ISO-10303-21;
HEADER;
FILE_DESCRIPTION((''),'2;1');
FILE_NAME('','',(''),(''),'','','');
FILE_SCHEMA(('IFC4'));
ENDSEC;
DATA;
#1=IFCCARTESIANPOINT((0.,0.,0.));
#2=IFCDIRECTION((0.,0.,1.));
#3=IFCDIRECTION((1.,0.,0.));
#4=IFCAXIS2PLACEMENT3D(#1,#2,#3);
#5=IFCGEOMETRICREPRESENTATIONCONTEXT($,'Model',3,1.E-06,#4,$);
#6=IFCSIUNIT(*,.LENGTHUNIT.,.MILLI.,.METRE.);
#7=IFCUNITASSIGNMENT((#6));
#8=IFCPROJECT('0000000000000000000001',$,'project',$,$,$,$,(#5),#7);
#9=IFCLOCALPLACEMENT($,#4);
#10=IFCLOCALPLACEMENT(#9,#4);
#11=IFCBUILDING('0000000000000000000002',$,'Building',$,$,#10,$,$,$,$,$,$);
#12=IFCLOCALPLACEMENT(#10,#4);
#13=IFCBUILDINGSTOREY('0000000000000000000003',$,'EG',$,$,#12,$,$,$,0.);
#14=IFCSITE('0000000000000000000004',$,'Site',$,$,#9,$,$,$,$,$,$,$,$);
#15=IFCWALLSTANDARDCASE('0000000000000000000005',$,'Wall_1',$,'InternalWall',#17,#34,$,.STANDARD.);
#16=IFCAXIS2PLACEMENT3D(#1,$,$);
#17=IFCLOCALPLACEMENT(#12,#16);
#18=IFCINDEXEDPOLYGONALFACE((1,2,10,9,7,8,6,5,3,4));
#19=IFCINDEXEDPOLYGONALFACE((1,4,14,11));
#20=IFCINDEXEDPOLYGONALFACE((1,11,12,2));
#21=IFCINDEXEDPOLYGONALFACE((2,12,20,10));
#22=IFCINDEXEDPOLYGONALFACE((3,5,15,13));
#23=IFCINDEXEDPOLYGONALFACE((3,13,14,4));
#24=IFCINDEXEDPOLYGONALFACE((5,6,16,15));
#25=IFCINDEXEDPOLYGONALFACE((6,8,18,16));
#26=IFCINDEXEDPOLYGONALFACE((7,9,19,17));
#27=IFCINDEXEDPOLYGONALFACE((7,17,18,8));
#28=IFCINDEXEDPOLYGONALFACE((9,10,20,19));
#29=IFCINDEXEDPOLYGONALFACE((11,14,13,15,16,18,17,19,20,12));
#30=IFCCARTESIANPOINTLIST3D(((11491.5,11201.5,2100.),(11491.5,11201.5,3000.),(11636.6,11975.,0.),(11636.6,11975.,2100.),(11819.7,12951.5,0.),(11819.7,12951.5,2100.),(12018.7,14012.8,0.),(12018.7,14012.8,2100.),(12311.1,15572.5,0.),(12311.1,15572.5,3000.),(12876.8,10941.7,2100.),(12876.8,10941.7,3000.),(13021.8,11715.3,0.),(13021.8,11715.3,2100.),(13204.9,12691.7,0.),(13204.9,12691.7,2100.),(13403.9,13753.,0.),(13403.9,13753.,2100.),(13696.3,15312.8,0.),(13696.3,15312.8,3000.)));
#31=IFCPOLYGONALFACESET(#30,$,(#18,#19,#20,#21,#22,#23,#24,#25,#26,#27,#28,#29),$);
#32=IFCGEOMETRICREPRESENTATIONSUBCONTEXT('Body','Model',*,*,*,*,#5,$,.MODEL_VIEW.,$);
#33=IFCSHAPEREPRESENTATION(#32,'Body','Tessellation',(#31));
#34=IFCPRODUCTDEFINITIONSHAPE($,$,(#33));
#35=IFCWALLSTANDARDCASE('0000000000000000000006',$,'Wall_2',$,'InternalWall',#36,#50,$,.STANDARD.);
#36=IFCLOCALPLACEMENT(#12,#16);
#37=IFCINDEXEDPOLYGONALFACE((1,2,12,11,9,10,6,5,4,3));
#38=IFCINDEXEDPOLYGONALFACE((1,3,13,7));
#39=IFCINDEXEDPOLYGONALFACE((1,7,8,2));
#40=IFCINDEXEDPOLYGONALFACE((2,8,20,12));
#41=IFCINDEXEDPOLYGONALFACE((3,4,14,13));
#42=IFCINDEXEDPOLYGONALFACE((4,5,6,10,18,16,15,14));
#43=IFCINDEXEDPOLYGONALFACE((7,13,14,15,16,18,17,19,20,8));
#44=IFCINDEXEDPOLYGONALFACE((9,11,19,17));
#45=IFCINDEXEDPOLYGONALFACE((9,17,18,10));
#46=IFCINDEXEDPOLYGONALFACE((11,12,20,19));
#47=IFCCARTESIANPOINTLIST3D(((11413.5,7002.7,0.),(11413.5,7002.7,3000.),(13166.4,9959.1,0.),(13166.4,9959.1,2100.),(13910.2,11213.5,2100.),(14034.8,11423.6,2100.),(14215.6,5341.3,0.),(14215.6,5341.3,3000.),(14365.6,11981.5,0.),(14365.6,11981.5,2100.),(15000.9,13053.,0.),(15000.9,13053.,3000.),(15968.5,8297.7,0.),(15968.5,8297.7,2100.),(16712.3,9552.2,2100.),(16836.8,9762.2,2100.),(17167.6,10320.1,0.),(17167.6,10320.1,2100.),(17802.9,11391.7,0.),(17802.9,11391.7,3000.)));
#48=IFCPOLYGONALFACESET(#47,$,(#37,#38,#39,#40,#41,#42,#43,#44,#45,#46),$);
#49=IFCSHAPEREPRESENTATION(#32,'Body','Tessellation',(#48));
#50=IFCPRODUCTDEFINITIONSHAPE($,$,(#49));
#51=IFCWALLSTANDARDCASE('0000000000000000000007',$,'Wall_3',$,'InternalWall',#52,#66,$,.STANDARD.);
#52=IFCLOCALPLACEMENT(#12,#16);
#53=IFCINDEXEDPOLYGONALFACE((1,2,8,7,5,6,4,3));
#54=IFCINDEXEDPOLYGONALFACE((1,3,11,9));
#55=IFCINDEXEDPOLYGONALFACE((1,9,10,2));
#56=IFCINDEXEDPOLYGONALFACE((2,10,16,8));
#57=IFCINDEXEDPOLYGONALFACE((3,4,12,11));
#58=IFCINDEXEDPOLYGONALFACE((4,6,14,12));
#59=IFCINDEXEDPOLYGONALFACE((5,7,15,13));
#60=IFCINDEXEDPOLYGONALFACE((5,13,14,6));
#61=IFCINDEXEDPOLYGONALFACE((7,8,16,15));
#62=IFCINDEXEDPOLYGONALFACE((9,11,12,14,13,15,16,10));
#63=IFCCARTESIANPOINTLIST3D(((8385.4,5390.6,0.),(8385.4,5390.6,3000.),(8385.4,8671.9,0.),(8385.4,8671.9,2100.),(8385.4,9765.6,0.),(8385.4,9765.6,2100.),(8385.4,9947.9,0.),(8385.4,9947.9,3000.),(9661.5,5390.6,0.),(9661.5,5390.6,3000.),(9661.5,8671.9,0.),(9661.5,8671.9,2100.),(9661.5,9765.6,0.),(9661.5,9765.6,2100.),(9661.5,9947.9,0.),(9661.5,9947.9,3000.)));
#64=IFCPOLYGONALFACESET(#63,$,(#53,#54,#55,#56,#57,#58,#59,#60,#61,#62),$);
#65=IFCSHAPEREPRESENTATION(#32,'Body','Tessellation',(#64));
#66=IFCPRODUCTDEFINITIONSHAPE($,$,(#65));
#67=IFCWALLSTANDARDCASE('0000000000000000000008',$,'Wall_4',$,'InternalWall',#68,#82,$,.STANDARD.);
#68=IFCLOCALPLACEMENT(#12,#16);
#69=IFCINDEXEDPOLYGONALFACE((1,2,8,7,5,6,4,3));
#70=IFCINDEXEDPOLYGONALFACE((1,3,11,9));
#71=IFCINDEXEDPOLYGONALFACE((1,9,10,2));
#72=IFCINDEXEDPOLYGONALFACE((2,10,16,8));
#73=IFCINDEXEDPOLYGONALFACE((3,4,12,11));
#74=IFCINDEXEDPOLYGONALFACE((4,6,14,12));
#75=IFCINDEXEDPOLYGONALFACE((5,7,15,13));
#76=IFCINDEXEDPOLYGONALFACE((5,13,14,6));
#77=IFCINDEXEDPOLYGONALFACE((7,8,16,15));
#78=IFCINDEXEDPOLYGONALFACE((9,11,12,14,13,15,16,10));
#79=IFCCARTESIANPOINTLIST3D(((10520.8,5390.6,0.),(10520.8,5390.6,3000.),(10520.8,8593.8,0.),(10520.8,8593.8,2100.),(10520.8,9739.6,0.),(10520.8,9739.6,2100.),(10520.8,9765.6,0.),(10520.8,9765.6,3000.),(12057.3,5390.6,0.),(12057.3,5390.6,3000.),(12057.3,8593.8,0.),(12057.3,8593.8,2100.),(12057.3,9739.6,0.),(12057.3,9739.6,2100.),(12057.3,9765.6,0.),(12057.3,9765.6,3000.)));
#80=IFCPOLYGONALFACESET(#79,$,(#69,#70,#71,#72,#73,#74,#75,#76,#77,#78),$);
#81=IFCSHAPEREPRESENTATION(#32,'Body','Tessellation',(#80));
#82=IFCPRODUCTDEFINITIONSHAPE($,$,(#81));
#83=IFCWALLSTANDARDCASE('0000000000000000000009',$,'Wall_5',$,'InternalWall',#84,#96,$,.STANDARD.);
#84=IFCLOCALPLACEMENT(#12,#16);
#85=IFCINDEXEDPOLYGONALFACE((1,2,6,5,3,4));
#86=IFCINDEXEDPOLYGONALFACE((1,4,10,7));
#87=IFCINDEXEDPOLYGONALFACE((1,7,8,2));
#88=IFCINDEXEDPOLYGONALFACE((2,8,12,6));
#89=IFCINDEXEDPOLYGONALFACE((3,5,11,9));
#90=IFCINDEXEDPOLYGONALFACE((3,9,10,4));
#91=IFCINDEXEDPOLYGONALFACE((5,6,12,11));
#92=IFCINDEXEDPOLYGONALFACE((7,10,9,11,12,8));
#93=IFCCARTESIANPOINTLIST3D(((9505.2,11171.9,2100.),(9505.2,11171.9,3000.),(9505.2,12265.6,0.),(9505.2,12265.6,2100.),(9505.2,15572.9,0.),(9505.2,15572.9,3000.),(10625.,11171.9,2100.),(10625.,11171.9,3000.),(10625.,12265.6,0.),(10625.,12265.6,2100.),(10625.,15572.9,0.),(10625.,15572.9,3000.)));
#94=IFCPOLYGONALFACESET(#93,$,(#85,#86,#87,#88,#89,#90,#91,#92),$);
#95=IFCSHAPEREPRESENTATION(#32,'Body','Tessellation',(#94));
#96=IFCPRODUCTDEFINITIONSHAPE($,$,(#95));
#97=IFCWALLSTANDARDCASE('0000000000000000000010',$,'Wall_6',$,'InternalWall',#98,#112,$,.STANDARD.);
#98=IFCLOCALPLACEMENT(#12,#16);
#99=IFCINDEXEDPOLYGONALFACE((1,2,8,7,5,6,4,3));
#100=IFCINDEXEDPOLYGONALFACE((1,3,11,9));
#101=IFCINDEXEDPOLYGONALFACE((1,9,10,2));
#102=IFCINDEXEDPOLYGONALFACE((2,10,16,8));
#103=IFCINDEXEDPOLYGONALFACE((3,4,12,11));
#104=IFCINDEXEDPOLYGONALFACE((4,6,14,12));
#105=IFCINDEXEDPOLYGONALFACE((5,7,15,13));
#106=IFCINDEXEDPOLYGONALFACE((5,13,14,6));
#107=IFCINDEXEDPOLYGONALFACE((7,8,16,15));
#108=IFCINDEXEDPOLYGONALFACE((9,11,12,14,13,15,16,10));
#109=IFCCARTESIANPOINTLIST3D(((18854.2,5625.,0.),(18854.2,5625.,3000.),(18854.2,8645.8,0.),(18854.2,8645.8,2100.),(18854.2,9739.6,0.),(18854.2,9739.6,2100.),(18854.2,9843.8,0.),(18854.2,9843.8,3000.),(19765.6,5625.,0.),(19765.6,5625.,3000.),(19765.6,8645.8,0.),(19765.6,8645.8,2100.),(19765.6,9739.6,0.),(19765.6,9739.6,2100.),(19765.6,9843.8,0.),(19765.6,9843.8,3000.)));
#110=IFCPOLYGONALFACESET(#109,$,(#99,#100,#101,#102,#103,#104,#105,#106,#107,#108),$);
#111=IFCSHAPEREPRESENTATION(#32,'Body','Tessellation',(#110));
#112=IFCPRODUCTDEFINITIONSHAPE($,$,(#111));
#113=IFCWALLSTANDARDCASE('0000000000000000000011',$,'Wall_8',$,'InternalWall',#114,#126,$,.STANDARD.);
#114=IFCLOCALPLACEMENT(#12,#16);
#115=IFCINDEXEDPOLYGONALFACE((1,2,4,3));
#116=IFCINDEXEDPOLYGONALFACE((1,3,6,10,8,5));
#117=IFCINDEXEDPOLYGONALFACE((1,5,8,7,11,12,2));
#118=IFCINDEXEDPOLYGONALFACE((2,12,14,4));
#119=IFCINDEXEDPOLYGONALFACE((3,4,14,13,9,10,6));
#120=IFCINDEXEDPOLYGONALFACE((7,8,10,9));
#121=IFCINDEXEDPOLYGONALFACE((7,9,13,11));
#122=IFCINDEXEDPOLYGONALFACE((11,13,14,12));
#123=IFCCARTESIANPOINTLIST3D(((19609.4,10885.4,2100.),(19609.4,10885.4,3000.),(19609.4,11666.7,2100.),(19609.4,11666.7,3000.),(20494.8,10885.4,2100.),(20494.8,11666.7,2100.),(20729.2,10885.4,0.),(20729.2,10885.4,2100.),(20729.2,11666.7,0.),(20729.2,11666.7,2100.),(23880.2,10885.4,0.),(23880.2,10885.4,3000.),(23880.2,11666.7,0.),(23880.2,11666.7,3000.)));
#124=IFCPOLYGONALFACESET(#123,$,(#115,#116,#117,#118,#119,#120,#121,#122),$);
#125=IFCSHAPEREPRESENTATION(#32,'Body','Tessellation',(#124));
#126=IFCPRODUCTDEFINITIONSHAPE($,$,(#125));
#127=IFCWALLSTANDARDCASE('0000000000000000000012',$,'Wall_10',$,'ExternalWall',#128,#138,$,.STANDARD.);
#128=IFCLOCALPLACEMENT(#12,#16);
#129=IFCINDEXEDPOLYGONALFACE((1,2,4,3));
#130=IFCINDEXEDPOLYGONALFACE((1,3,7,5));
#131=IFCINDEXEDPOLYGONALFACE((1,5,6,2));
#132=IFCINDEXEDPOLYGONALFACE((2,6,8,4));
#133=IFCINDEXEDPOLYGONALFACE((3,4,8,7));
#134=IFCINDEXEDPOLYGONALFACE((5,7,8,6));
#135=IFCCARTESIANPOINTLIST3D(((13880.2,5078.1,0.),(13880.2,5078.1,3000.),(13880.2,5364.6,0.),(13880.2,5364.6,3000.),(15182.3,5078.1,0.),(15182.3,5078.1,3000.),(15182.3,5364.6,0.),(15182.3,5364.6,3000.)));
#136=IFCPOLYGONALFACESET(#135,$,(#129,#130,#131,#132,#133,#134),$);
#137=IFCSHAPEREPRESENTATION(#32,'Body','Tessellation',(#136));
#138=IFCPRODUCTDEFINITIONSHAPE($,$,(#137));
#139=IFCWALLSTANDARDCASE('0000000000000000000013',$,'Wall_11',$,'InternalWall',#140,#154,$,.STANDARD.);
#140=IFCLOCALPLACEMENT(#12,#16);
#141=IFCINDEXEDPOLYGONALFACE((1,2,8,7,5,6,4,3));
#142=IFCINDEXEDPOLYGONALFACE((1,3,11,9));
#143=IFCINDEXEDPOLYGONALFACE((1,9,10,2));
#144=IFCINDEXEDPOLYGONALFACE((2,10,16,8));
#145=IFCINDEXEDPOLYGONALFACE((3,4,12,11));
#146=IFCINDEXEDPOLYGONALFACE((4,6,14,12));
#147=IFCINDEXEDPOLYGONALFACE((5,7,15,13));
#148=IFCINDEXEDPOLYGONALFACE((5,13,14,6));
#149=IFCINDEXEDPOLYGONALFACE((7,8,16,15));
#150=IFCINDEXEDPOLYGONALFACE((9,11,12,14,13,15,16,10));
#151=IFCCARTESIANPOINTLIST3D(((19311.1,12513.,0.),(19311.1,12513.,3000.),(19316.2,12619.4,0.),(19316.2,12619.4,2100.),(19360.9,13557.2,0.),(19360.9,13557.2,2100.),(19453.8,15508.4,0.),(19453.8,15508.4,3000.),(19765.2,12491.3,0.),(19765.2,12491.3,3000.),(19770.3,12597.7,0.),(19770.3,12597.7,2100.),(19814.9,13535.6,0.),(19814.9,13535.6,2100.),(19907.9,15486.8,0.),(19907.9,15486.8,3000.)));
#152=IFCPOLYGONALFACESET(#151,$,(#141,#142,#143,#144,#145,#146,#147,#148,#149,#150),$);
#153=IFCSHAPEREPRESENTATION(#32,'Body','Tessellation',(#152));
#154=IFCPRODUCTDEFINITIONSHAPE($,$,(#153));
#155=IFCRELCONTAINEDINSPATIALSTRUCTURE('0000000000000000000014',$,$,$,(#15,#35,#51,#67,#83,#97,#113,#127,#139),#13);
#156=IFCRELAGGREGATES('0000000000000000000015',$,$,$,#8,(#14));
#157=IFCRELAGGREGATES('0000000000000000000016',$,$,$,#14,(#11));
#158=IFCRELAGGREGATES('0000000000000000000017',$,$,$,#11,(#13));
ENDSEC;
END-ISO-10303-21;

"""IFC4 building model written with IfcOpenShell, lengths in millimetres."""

from ifc_helpers import new_model, si_unit, frame, origin_with_axes, place, context, subcontext, project, spatial, rectangle, extrude, element, save


model = new_model("IFC4")

# Units and contexts
model_context = context("Model", 3, precision=1e-06, world=origin_with_axes())
body_context = subcontext(model_context, "Body", "Model", "MODEL_VIEW")
ifc_project = project(units=[si_unit("LENGTHUNIT", "METRE", prefix="MILLI")], contexts=[model_context])

# Site, building, storey
site_placement = place(None, origin_with_axes())
site = spatial("IfcSite", under=ifc_project, at=site_placement, Name="Site")
building_placement = place(site_placement, origin_with_axes())
building = spatial("IfcBuilding", under=site, at=building_placement, Name="Building")
storey_placement = place(building_placement, origin_with_axes())
storey = spatial("IfcBuildingStorey", under=building, at=storey_placement, Name="EG", Elevation=0.0)

# Walls, openings
wall_1_placement = place(storey_placement, origin_with_axes())
wall_1 = element("IfcWallStandardCase", 1, at=wall_1_placement, inside=storey, Name="Wall_1", ObjectType="InternalWall", PredefinedType="STANDARD", context=body_context, shape_type="SweptSolid", body=[
    extrude(rectangle(XDim=4447.2, YDim=1409.4), frame((12593.9, 13257.1, 0.0), z_axis=(0.0, 0.0, 1.0), x_axis=(0.184288, 0.982872, 0.0)), (0.0, 0.0, 1.0), 3000.0),
])
opening_1_placement = place(wall_1_placement, origin_with_axes())
element("IfcOpeningElement", 2, at=opening_1_placement, inside=storey, cuts=wall_1, context=body_context, shape_type="SweptSolid", body=[
    extrude(rectangle(XDim=1079.8, YDim=1409.4), frame((12611.8, 13352.3, 0.0), z_axis=(0.0, 0.0, 1.0), x_axis=(0.184288, 0.982872, 0.0)), (0.0, 0.0, 1.0), 2100.0),
])
opening_2_placement = place(wall_1_placement, origin_with_axes())
element("IfcOpeningElement", 3, at=opening_2_placement, inside=storey, cuts=wall_1, context=body_context, shape_type="SweptSolid", body=[
    extrude(rectangle(XDim=787.1, YDim=1409.4), frame((12256.7, 11458.4, 0.0), z_axis=(0.0, 0.0, 1.0), x_axis=(0.184288, 0.982872, 0.0)), (0.0, 0.0, 1.0), 2100.0),
])
wall_2_placement = place(storey_placement, origin_with_axes())
wall_2 = element("IfcWallStandardCase", 4, at=wall_2_placement, inside=storey, Name="Wall_2", ObjectType="InternalWall", PredefinedType="STANDARD", context=body_context, shape_type="SweptSolid", body=[
    extrude(rectangle(XDim=7033.9, YDim=3257.5), frame((14608.2, 9197.2, 0.0), z_axis=(0.0, 0.0, 1.0), x_axis=(-0.510011, -0.860168, 0.0)), (0.0, 0.0, 1.0), 3000.0),
])
opening_3_placement = place(wall_2_placement, origin_with_axes())
element("IfcOpeningElement", 5, at=opening_3_placement, inside=storey, cuts=wall_2, context=body_context, shape_type="SweptSolid", body=[
    extrude(rectangle(XDim=1702.6, YDim=3257.5), frame((15001.6, 9860.7, 0.0), z_axis=(0.0, 0.0, 1.0), x_axis=(-0.510011, -0.860168, 0.0)), (0.0, 0.0, 1.0), 2100.0),
])
opening_4_placement = place(wall_2_placement, origin_with_axes())
element("IfcOpeningElement", 6, at=opening_4_placement, inside=storey, cuts=wall_2, context=body_context, shape_type="SweptSolid", body=[
    extrude(rectangle(XDim=892.8, YDim=3257.5), frame((15538.9, 10766.8, 0.0), z_axis=(0.0, 0.0, 1.0), x_axis=(-0.510011, -0.860168, 0.0)), (0.0, 0.0, 1.0), 2100.0),
])
wall_3_placement = place(storey_placement, origin_with_axes())
wall_3 = element("IfcWallStandardCase", 7, at=wall_3_placement, inside=storey, Name="Wall_3", ObjectType="InternalWall", PredefinedType="STANDARD", context=body_context, shape_type="SweptSolid", body=[
    extrude(rectangle(XDim=4557.3, YDim=1276.0), frame((9023.4, 7669.3, 0.0), z_axis=(0.0, 0.0, 1.0), x_axis=(0.0, 1.0, 0.0)), (0.0, 0.0, 1.0), 3000.0),
])
opening_5_placement = place(wall_3_placement, origin_with_axes())
element("IfcOpeningElement", 8, at=opening_5_placement, inside=storey, cuts=wall_3, context=body_context, shape_type="SweptSolid", body=[
    extrude(rectangle(XDim=1093.8, YDim=1276.0), frame((9023.4, 9218.8, 0.0), z_axis=(0.0, 0.0, 1.0), x_axis=(0.0, 1.0, 0.0)), (0.0, 0.0, 1.0), 2100.0),
])
opening_6_placement = place(wall_3_placement, origin_with_axes())
element("IfcOpeningElement", 9, at=opening_6_placement, inside=storey, cuts=wall_3, context=body_context, shape_type="SweptSolid", body=[
    extrude(rectangle(XDim=900.0, YDim=1276.0), frame((8050.2, 10554.7, 0.0), z_axis=(0.0, 0.0, 1.0), x_axis=(0.0, 1.0, 0.0)), (0.0, 0.0, 1.0), 2100.0),
])

# Walls, openings
wall_4_placement = place(storey_placement, origin_with_axes())
wall_4 = element("IfcWallStandardCase", 10, at=wall_4_placement, inside=storey, Name="Wall_4", ObjectType="InternalWall", PredefinedType="STANDARD", context=body_context, shape_type="SweptSolid", body=[
    extrude(rectangle(XDim=4375.0, YDim=1536.5), frame((11289.1, 7578.1, 0.0), z_axis=(0.0, 0.0, 1.0), x_axis=(0.0, 1.0, 0.0)), (0.0, 0.0, 1.0), 3000.0),
])
opening_7_placement = place(wall_4_placement, origin_with_axes())
element("IfcOpeningElement", 11, at=opening_7_placement, inside=storey, cuts=wall_4, context=body_context, shape_type="SweptSolid", body=[
    extrude(rectangle(XDim=1145.8, YDim=1536.5), frame((11289.1, 9166.7, 0.0), z_axis=(0.0, 0.0, 1.0), x_axis=(0.0, 1.0, 0.0)), (0.0, 0.0, 1.0), 2100.0),
])
wall_5_placement = place(storey_placement, origin_with_axes())
wall_5 = element("IfcWallStandardCase", 12, at=wall_5_placement, inside=storey, Name="Wall_5", ObjectType="InternalWall", PredefinedType="STANDARD", context=body_context, shape_type="SweptSolid", body=[
    extrude(rectangle(XDim=4401.0, YDim=1119.8), frame((10065.1, 13372.4, 0.0), z_axis=(0.0, 0.0, 1.0), x_axis=(0.0, -1.0, 0.0)), (0.0, 0.0, 1.0), 3000.0),
])
opening_8_placement = place(wall_5_placement, origin_with_axes())
element("IfcOpeningElement", 13, at=opening_8_placement, inside=storey, cuts=wall_5, context=body_context, shape_type="SweptSolid", body=[
    extrude(rectangle(XDim=1093.8, YDim=1119.8), frame((10065.1, 11718.8, 0.0), z_axis=(0.0, 0.0, 1.0), x_axis=(0.0, -1.0, 0.0)), (0.0, 0.0, 1.0), 2100.0),
])
wall_6_placement = place(storey_placement, origin_with_axes())
wall_6 = element("IfcWallStandardCase", 14, at=wall_6_placement, inside=storey, Name="Wall_6", ObjectType="InternalWall", PredefinedType="STANDARD", context=body_context, shape_type="SweptSolid", body=[
    extrude(rectangle(XDim=4218.8, YDim=911.5), frame((19309.9, 7734.4, 0.0), z_axis=(0.0, 0.0, 1.0), x_axis=(0.0, 1.0, 0.0)), (0.0, 0.0, 1.0), 3000.0),
])
opening_9_placement = place(wall_6_placement, origin_with_axes())
element("IfcOpeningElement", 15, at=opening_9_placement, inside=storey, cuts=wall_6, context=body_context, shape_type="SweptSolid", body=[
    extrude(rectangle(XDim=1093.8, YDim=911.5), frame((19309.9, 9192.7, 0.0), z_axis=(0.0, 0.0, 1.0), x_axis=(0.0, 1.0, 0.0)), (0.0, 0.0, 1.0), 2100.0),
])

# Wall, openings
wall_7_placement = place(storey_placement, origin_with_axes())
wall_7 = element("IfcWallStandardCase", 16, at=wall_7_placement, inside=storey, Name="Wall_8", ObjectType="InternalWall", PredefinedType="STANDARD", context=body_context, shape_type="SweptSolid", body=[
    extrude(rectangle(XDim=4270.8, YDim=781.2), frame((21744.8, 11276.0, 0.0), z_axis=(0.0, 0.0, 1.0), x_axis=(1.0, 0.0, 0.0)), (0.0, 0.0, 1.0), 3000.0),
])
opening_10_placement = place(wall_7_placement, origin_with_axes())
element("IfcOpeningElement", 17, at=opening_10_placement, inside=storey, cuts=wall_7, context=body_context, shape_type="SweptSolid", body=[
    extrude(rectangle(XDim=1119.8, YDim=781.2), frame((20169.3, 11276.0, 0.0), z_axis=(0.0, 0.0, 1.0), x_axis=(1.0, 0.0, 0.0)), (0.0, 0.0, 1.0), 2100.0),
])
opening_11_placement = place(wall_7_placement, origin_with_axes())
element("IfcOpeningElement", 18, at=opening_11_placement, inside=storey, cuts=wall_7, context=body_context, shape_type="SweptSolid", body=[
    extrude(rectangle(XDim=885.4, YDim=781.2), frame((20052.1, 11276.0, 0.0), z_axis=(0.0, 0.0, 1.0), x_axis=(1.0, 0.0, 0.0)), (0.0, 0.0, 1.0), 2100.0),
])

# Wall
wall_8_placement = place(storey_placement, origin_with_axes())
element("IfcWallStandardCase", 19, at=wall_8_placement, inside=storey, Name="Wall_10", ObjectType="ExternalWall", PredefinedType="STANDARD", context=body_context, shape_type="SweptSolid", body=[
    extrude(rectangle(XDim=1302.1, YDim=286.5), frame((14531.3, 5221.4, 0.0), z_axis=(0.0, 0.0, 1.0), x_axis=(1.0, 0.0, 0.0)), (0.0, 0.0, 1.0), 3000.0),
])

# Wall, opening
wall_9_placement = place(storey_placement, origin_with_axes())
wall_9 = element("IfcWallStandardCase", 20, at=wall_9_placement, inside=storey, Name="Wall_11", ObjectType="InternalWall", PredefinedType="STANDARD", context=body_context, shape_type="SweptSolid", body=[
    extrude(rectangle(XDim=2998.8, YDim=454.6), frame((19609.5, 13999.9, 0.0), z_axis=(0.0, 0.0, 1.0), x_axis=(-0.047565, -0.998868, 0.0)), (0.0, 0.0, 1.0), 3000.0),
])
opening_12_placement = place(wall_9_placement, origin_with_axes())
element("IfcOpeningElement", 21, at=opening_12_placement, inside=storey, cuts=wall_9, context=body_context, shape_type="SweptSolid", body=[
    extrude(rectangle(XDim=938.9, YDim=454.6), frame((19565.6, 13077.5, 0.0), z_axis=(0.0, 0.0, 1.0), x_axis=(-0.047565, -0.998868, 0.0)), (0.0, 0.0, 1.0), 2100.0),
])

save(model, "model.ifc")
